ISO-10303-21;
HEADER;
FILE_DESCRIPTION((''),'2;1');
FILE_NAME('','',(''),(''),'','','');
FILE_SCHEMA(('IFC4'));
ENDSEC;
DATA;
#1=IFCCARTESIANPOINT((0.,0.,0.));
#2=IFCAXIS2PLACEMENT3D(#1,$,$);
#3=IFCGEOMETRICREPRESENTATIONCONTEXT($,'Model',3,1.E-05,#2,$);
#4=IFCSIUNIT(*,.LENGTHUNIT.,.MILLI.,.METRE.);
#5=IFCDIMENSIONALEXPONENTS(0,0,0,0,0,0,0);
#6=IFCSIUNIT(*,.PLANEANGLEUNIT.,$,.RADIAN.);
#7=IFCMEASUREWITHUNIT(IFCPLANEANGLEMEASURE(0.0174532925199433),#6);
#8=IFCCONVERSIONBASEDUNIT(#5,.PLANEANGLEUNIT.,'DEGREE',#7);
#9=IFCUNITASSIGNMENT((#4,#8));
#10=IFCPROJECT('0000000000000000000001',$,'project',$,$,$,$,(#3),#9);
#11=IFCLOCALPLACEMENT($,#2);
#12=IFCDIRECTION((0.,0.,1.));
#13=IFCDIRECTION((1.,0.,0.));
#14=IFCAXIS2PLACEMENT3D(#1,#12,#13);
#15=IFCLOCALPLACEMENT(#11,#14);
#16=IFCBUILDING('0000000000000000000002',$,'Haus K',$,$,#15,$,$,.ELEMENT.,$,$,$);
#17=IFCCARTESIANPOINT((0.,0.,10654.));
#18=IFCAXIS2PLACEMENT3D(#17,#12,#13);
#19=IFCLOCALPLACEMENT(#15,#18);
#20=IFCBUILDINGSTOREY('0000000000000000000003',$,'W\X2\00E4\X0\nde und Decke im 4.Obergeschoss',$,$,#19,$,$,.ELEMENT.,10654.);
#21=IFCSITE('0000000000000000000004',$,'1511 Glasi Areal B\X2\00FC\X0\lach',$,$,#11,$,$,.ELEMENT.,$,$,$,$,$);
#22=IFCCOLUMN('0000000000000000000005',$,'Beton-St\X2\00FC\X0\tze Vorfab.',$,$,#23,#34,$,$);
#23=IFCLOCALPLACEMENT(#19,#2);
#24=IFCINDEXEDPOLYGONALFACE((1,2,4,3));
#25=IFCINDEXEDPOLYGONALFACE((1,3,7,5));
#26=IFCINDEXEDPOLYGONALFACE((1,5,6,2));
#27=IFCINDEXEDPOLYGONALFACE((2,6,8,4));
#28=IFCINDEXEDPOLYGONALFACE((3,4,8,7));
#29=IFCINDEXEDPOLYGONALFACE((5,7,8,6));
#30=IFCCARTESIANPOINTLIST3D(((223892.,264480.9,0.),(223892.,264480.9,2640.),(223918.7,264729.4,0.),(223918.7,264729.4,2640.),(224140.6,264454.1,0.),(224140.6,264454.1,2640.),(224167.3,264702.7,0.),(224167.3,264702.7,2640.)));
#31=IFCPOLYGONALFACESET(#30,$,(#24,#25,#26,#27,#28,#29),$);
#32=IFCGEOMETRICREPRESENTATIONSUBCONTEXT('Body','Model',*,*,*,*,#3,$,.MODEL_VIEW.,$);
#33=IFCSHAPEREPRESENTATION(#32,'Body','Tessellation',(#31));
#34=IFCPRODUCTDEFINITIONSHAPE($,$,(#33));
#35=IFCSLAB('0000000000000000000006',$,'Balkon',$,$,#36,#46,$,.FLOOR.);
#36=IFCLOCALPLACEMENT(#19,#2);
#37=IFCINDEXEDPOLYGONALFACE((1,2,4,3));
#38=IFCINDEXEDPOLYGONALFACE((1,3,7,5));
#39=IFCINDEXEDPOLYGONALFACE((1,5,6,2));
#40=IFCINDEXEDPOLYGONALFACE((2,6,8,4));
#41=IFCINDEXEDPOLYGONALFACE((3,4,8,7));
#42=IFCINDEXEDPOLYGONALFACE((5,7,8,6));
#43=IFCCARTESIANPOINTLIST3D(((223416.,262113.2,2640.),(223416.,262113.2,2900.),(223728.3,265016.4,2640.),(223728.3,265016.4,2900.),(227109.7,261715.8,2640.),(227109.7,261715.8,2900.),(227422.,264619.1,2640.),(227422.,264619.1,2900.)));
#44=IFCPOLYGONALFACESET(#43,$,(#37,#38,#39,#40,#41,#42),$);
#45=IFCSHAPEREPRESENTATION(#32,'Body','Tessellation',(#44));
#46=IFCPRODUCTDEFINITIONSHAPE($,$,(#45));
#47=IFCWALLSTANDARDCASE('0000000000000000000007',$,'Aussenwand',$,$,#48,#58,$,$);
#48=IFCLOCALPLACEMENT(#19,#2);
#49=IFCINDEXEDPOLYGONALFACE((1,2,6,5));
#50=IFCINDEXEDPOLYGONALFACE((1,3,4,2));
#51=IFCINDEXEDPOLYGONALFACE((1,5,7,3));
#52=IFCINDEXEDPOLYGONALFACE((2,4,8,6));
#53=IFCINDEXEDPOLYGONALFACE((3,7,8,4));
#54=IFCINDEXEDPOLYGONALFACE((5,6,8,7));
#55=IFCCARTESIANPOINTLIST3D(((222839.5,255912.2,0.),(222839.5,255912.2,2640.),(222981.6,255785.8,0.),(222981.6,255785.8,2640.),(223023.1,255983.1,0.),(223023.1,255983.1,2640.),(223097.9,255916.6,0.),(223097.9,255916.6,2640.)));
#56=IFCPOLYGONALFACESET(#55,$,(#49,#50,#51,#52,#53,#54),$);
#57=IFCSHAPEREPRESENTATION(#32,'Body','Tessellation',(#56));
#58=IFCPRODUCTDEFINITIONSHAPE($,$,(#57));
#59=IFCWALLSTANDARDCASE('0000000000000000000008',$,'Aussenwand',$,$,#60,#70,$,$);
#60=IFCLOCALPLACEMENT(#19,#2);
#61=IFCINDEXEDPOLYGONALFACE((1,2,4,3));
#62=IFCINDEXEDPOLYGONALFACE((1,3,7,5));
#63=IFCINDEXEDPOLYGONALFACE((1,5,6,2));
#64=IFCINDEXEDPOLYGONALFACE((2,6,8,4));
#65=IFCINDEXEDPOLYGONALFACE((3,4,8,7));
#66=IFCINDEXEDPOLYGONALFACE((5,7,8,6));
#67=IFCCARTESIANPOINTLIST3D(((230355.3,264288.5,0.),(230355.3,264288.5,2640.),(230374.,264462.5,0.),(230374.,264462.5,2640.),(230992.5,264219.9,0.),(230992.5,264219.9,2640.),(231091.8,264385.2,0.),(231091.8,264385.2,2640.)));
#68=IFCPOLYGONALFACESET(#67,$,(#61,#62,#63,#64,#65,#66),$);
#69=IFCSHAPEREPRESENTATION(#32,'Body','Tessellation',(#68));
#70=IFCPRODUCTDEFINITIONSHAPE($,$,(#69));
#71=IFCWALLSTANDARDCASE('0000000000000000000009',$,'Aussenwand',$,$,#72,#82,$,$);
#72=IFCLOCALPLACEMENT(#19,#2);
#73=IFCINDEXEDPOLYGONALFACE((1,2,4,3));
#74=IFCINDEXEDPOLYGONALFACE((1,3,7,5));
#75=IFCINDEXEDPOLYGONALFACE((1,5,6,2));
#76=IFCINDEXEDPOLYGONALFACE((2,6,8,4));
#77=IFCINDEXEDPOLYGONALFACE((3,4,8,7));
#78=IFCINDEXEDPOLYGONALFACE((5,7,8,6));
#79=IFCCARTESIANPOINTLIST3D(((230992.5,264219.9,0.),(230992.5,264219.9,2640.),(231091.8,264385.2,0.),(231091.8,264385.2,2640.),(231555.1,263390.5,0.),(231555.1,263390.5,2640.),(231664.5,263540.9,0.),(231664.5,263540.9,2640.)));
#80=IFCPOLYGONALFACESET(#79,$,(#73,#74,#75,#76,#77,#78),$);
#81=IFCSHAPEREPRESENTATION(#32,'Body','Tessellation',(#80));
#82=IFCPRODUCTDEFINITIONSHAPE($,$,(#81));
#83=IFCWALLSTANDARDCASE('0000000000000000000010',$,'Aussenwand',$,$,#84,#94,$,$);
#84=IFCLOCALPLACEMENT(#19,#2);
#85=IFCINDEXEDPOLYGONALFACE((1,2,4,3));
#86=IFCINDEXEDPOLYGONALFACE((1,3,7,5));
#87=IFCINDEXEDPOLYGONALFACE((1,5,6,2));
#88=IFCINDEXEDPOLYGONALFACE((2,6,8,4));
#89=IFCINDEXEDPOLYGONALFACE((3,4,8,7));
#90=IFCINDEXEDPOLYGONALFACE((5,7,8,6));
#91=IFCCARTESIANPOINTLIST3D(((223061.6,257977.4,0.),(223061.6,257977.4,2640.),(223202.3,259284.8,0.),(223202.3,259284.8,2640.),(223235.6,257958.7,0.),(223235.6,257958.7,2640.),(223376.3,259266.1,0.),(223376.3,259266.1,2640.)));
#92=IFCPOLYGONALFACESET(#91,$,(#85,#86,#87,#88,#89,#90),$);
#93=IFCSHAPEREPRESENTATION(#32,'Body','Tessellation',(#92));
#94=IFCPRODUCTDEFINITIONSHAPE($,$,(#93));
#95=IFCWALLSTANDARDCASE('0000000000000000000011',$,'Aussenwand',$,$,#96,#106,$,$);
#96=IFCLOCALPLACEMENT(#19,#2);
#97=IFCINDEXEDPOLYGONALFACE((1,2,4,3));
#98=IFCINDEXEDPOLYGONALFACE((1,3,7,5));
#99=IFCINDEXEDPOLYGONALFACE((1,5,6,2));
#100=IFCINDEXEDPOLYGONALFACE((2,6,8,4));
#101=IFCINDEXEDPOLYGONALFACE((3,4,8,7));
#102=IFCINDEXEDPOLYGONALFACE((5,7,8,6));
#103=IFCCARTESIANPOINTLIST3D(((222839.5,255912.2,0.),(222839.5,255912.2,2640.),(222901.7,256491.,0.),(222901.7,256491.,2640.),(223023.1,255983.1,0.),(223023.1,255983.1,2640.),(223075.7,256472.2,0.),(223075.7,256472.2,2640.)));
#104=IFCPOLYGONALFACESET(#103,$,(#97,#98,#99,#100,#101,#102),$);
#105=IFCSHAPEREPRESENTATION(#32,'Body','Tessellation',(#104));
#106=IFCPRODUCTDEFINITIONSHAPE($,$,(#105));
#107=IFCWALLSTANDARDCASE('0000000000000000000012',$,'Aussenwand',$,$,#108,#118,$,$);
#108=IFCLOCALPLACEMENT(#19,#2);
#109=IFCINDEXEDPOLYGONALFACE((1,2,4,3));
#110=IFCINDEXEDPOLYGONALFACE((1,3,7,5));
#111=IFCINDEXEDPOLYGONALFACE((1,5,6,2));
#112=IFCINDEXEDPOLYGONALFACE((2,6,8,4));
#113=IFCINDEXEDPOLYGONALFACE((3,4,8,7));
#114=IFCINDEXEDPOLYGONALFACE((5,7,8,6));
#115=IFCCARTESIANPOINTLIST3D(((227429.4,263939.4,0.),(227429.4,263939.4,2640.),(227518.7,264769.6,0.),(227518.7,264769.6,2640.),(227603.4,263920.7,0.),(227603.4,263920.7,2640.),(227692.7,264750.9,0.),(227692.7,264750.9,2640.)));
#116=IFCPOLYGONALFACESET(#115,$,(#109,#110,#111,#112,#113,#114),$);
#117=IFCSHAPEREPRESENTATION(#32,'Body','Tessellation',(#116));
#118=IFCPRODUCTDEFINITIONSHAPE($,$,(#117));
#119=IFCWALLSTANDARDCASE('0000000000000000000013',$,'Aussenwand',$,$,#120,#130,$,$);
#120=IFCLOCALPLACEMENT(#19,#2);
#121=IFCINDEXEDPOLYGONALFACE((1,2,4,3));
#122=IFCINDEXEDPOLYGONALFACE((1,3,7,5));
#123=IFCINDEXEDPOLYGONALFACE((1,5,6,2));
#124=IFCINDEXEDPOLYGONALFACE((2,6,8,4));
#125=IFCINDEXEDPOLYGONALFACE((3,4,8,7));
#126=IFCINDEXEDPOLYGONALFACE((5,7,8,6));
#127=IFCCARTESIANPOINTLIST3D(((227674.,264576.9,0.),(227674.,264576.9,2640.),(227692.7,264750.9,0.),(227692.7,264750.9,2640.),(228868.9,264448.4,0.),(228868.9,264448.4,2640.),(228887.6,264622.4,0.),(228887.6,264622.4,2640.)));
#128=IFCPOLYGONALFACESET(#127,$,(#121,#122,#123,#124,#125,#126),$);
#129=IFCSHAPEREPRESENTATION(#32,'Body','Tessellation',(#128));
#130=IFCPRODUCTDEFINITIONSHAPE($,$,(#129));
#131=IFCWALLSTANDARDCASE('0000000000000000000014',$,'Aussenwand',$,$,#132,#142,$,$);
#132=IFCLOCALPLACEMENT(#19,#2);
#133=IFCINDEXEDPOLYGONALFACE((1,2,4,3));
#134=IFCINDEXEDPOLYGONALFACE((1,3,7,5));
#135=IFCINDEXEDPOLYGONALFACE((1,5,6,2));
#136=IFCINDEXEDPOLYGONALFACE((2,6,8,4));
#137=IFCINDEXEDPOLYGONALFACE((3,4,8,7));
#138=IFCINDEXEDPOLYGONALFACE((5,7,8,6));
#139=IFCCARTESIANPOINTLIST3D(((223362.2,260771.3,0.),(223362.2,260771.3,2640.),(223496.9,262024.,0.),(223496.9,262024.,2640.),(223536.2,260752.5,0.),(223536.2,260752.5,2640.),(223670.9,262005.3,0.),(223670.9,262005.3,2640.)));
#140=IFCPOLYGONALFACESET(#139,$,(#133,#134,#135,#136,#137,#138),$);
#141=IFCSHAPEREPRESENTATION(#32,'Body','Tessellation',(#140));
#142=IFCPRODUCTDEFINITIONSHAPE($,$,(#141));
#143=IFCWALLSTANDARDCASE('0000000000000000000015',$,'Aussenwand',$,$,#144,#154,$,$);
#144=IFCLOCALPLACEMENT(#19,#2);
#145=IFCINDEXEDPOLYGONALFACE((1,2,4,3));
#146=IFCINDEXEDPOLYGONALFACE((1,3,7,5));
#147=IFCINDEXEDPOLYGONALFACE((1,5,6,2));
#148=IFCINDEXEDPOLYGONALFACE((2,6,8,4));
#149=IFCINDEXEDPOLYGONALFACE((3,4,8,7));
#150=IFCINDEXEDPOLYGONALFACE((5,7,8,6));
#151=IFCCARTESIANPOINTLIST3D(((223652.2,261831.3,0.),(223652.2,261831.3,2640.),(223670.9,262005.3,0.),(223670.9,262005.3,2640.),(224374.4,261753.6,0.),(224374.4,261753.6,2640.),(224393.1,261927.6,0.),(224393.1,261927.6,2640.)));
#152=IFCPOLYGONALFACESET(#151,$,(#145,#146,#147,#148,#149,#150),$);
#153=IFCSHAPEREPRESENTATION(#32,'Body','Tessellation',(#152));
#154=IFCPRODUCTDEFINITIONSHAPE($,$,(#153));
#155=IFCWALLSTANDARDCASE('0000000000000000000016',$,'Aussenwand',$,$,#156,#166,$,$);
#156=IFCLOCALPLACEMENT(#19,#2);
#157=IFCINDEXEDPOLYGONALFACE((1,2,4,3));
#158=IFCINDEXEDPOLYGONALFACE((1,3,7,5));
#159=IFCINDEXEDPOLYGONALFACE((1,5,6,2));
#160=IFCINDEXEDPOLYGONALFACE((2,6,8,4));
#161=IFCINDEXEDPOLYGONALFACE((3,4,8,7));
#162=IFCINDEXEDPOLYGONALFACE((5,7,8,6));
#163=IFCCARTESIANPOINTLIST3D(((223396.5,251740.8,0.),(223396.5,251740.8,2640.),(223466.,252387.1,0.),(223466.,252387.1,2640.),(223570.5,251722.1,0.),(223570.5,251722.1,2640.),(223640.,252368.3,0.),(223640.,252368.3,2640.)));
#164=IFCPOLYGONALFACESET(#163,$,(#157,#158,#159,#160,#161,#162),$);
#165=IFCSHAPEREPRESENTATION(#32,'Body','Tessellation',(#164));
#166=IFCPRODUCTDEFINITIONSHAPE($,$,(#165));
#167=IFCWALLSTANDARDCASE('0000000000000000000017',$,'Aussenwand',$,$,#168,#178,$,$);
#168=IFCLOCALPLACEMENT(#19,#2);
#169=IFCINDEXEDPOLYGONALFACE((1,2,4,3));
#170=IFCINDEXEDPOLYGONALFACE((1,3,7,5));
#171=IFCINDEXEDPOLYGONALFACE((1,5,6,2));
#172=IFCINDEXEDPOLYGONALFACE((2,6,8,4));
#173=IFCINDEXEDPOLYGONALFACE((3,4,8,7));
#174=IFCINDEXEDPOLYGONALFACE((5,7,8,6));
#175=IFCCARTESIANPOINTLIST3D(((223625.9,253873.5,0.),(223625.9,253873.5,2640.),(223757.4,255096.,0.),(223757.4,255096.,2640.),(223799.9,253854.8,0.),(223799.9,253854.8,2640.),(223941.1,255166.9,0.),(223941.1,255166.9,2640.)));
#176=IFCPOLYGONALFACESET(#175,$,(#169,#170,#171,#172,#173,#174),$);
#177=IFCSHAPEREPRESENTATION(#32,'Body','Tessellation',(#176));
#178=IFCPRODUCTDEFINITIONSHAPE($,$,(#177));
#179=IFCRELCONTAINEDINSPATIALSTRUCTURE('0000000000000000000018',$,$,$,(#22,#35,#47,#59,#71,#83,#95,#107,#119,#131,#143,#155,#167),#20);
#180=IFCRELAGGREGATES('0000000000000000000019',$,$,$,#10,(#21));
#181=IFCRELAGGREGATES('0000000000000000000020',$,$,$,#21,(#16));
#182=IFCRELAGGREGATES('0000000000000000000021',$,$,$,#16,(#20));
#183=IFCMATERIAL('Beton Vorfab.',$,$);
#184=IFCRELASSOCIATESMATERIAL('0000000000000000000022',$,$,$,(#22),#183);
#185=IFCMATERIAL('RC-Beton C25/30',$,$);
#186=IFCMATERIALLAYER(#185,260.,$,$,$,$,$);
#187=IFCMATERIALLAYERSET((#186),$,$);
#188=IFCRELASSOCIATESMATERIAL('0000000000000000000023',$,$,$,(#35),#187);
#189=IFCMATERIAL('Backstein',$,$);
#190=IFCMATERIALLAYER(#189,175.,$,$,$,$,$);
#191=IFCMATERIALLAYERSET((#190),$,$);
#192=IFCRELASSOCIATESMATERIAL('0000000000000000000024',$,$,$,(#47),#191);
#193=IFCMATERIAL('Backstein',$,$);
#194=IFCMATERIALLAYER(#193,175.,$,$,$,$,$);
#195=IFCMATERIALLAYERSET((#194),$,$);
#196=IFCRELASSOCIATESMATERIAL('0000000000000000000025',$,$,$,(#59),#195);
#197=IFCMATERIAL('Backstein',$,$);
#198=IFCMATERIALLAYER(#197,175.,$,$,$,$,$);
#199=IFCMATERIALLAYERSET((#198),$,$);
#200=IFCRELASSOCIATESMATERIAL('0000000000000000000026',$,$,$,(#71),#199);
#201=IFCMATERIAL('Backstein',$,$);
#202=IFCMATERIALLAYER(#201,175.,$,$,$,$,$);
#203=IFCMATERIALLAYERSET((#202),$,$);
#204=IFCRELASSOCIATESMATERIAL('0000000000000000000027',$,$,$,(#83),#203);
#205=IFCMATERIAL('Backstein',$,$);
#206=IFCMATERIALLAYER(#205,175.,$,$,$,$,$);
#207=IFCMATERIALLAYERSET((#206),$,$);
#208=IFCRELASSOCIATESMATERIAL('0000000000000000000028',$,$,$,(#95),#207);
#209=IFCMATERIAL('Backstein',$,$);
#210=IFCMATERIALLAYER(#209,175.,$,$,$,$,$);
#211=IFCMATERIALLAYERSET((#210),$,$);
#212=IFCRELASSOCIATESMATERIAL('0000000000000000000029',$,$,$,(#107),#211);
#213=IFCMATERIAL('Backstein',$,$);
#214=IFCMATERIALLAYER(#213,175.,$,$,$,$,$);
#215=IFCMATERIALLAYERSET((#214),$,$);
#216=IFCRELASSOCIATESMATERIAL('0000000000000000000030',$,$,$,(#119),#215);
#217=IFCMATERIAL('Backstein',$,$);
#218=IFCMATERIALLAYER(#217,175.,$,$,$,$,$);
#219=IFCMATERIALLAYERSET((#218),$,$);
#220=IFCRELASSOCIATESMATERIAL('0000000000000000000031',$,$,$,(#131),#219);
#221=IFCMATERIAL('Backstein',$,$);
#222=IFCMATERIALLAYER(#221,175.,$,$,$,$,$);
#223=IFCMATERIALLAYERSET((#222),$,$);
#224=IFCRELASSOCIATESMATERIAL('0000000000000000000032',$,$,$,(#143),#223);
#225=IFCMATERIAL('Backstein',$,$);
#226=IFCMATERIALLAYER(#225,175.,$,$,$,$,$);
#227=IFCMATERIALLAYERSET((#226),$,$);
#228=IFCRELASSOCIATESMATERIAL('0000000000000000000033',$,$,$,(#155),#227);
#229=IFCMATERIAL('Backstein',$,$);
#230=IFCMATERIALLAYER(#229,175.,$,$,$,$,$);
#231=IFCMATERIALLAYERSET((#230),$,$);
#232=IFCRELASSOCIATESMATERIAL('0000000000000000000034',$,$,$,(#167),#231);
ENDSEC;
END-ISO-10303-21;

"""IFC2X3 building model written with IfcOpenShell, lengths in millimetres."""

from ifc_helpers import new_model, entity, si_unit, converted_unit, frame, frame_2d, origin, origin_with_axes, place, context, subcontext, project, spatial, polyline, rectangle, outline, extrude, material, layer, layer_set, layer_usage, element, save


model = new_model("IFC2X3")

# Units and contexts
model_context = context("Model", 3, precision=1e-05, world=origin())
body_context = subcontext(model_context, "Body", "Model", "MODEL_VIEW")
ifc_project = project(units=[si_unit("LENGTHUNIT", "METRE", prefix="MILLI"), converted_unit("PLANEANGLEUNIT", "DEGREE", entity("IfcPlaneAngleMeasure", 0.0174532925199433), si_unit("PLANEANGLEUNIT", "RADIAN"), dimensions=[0, 0, 0, 0, 0, 0, 0])], contexts=[model_context])

# Site, building, storey
site_placement = place(None, origin())
site = spatial("IfcSite", under=ifc_project, at=site_placement, Name="1511 Glasi Areal Bülach", CompositionType="ELEMENT")
building_placement = place(site_placement, origin_with_axes())
building = spatial("IfcBuilding", under=site, at=building_placement, Name="Haus K", CompositionType="ELEMENT")
storey_placement = place(building_placement, frame((0.0, 0.0, 10654.0), z_axis=(0.0, 0.0, 1.0), x_axis=(1.0, 0.0, 0.0)))
storey = spatial("IfcBuildingStorey", under=building, at=storey_placement, Name="Wände und Decke im 4.Obergeschoss", CompositionType="ELEMENT", Elevation=10654.0)

# Column
ifc_material_1 = material(Name="Beton Vorfab.")
column_placement = place(storey_placement, frame((223892.0, 264480.9, 0.0), z_axis=(0.0, 0.0, 1.0), x_axis=(1.0, 0.0, 0.0)))
element("IfcColumn", 1, at=column_placement, inside=storey, material=ifc_material_1, Name="Beton-Stütze Vorfab.", context=body_context, shape_type="SweptSolid", body=[
    extrude(rectangle(XDim=250.0, YDim=250.0, at=frame_2d((137.7, 110.9), x_axis=(0.994264, -0.106958))), origin_with_axes(), (0.0, 0.0, 1.0), 2640.0),
])

# Slab
ifc_material_2 = material(Name="RC-Beton C25/30")
ifc_layer_1 = layer(ifc_material_2, 260.0)
ifc_layer_set_1 = layer_set([ifc_layer_1])
ifc_layer_usage_1 = layer_usage(ifc_layer_set_1, "AXIS3", "POSITIVE", 0.0)
slab_placement = place(storey_placement, frame((223728.3, 265016.4, 2640.0), z_axis=(0.0, 0.0, 1.0), x_axis=(1.0, 0.0, 0.0)))
element("IfcSlab", 2, at=slab_placement, inside=storey, material=ifc_layer_usage_1, Name="Balkon", PredefinedType="FLOOR", context=body_context, shape_type="SweptSolid", body=[
    extrude(rectangle(XDim=2920.0, YDim=3715.0, at=frame_2d((1690.7, -1650.3), x_axis=(-0.106958, -0.994264))), origin_with_axes(), (0.0, 0.0, 1.0), 260.0),
])

# Walls
ifc_material_3 = material(Name="Backstein")
ifc_layer_2 = layer(ifc_material_3, 175.0)
ifc_layer_set_2 = layer_set([ifc_layer_2])
ifc_layer_usage_2 = layer_usage(ifc_layer_set_2, "AXIS2", "POSITIVE", 0.0)
wall_1_placement = place(storey_placement, frame((222839.5, 255912.2, 0.0), z_axis=(0.0, 0.0, 1.0), x_axis=(0.747334, -0.664448, 0.0)))
element("IfcWallStandardCase", 3, at=wall_1_placement, inside=storey, material=ifc_layer_usage_2, Name="Aussenwand", context=body_context, shape_type="SweptSolid", body=[
    extrude(outline(polyline([(0.0, 0.0), (190.2, 0.0), (190.2, 175.0), (90.1, 175.0), (0.0, 0.0)])), origin_with_axes(), (0.0, 0.0, 1.0), 2640.0),
])
ifc_material_4 = material(Name="Backstein")
ifc_layer_3 = layer(ifc_material_4, 175.0)
ifc_layer_set_3 = layer_set([ifc_layer_3])
ifc_layer_usage_3 = layer_usage(ifc_layer_set_3, "AXIS2", "POSITIVE", 0.0)
wall_2_placement = place(storey_placement, frame((231091.8, 264385.2, 0.0), z_axis=(0.0, 0.0, 1.0), x_axis=(-0.994264, 0.106958, 0.0)))
element("IfcWallStandardCase", 4, at=wall_2_placement, inside=storey, material=ifc_layer_usage_3, Name="Aussenwand", context=body_context, shape_type="SweptSolid", body=[
    extrude(outline(polyline([(0.0, 0.0), (721.9, 0.0), (721.9, 175.0), (81.1, 175.0), (0.0, 0.0)])), origin_with_axes(), (0.0, 0.0, 1.0), 2640.0),
])
ifc_material_5 = material(Name="Backstein")
ifc_layer_4 = layer(ifc_material_5, 175.0)
ifc_layer_set_4 = layer_set([ifc_layer_4])
ifc_layer_usage_4 = layer_usage(ifc_layer_set_4, "AXIS2", "POSITIVE", 0.0)
wall_3_placement = place(storey_placement, frame((231664.5, 263540.9, 0.0), z_axis=(0.0, 0.0, 1.0), x_axis=(-0.561361, 0.827571, 0.0)))
element("IfcWallStandardCase", 5, at=wall_3_placement, inside=storey, material=ifc_layer_usage_4, Name="Aussenwand", context=body_context, shape_type="SweptSolid", body=[
    extrude(outline(polyline([(0.0, 0.0), (1020.3, 0.0), (939.2, 175.0), (-63.0, 175.0), (0.0, 0.0)])), origin_with_axes(), (0.0, 0.0, 1.0), 2640.0),
])
ifc_material_6 = material(Name="Backstein")
ifc_layer_5 = layer(ifc_material_6, 175.0)
ifc_layer_set_5 = layer_set([ifc_layer_5])
ifc_layer_usage_5 = layer_usage(ifc_layer_set_5, "AXIS2", "POSITIVE", 0.0)
wall_4_placement = place(storey_placement, frame((223202.3, 259284.8, 0.0), z_axis=(0.0, 0.0, 1.0), x_axis=(-0.106958, -0.994264, 0.0)))
element("IfcWallStandardCase", 6, at=wall_4_placement, inside=storey, material=ifc_layer_usage_5, Name="Aussenwand", context=body_context, shape_type="SweptSolid", body=[
    extrude(rectangle(XDim=1315.0, YDim=175.0, at=frame_2d((657.5, 87.5), x_axis=(1.0, 0.0))), origin_with_axes(), (0.0, 0.0, 1.0), 2640.0),
])
ifc_material_7 = material(Name="Backstein")
ifc_layer_6 = layer(ifc_material_7, 175.0)
ifc_layer_set_6 = layer_set([ifc_layer_6])
ifc_layer_usage_6 = layer_usage(ifc_layer_set_6, "AXIS2", "POSITIVE", 0.0)
wall_5_placement = place(storey_placement, frame((222901.7, 256491.0, 0.0), z_axis=(0.0, 0.0, 1.0), x_axis=(-0.106958, -0.994264, 0.0)))
element("IfcWallStandardCase", 7, at=wall_5_placement, inside=storey, material=ifc_layer_usage_6, Name="Aussenwand", context=body_context, shape_type="SweptSolid", body=[
    extrude(outline(polyline([(0.0, 0.0), (582.1, 0.0), (492.0, 175.0), (0.0, 175.0), (0.0, 0.0)])), origin_with_axes(), (0.0, 0.0, 1.0), 2640.0),
])
ifc_material_8 = material(Name="Backstein")
ifc_layer_7 = layer(ifc_material_8, 175.0)
ifc_layer_set_7 = layer_set([ifc_layer_7])
ifc_layer_usage_7 = layer_usage(ifc_layer_set_7, "AXIS2", "POSITIVE", 0.0)
wall_6_placement = place(storey_placement, frame((227518.7, 264769.6, 0.0), z_axis=(0.0, 0.0, 1.0), x_axis=(-0.106958, -0.994264, 0.0)))
element("IfcWallStandardCase", 8, at=wall_6_placement, inside=storey, material=ifc_layer_usage_7, Name="Aussenwand", context=body_context, shape_type="SweptSolid", body=[
    extrude(rectangle(XDim=835.0, YDim=175.0, at=frame_2d((417.5, 87.5), x_axis=(1.0, 0.0))), origin_with_axes(), (0.0, 0.0, 1.0), 2640.0),
])
ifc_material_9 = material(Name="Backstein")
ifc_layer_8 = layer(ifc_material_9, 175.0)
ifc_layer_set_8 = layer_set([ifc_layer_8])
ifc_layer_usage_8 = layer_usage(ifc_layer_set_8, "AXIS2", "POSITIVE", 0.0)
wall_7_placement = place(storey_placement, frame((228887.6, 264622.4, 0.0), z_axis=(0.0, 0.0, 1.0), x_axis=(-0.994264, 0.106958, 0.0)))
element("IfcWallStandardCase", 9, at=wall_7_placement, inside=storey, material=ifc_layer_usage_8, Name="Aussenwand", context=body_context, shape_type="SweptSolid", body=[
    extrude(rectangle(XDim=1201.8, YDim=175.0, at=frame_2d((600.9, 87.5), x_axis=(1.0, 0.0))), origin_with_axes(), (0.0, 0.0, 1.0), 2640.0),
])
ifc_material_10 = material(Name="Backstein")
ifc_layer_9 = layer(ifc_material_10, 175.0)
ifc_layer_set_9 = layer_set([ifc_layer_9])
ifc_layer_usage_9 = layer_usage(ifc_layer_set_9, "AXIS2", "POSITIVE", 0.0)
wall_8_placement = place(storey_placement, frame((223496.9, 262024.0, 0.0), z_axis=(0.0, 0.0, 1.0), x_axis=(-0.106958, -0.994264, 0.0)))
element("IfcWallStandardCase", 10, at=wall_8_placement, inside=storey, material=ifc_layer_usage_9, Name="Aussenwand", context=body_context, shape_type="SweptSolid", body=[
    extrude(rectangle(XDim=1260.0, YDim=175.0, at=frame_2d((630.0, 87.5), x_axis=(1.0, 0.0))), origin_with_axes(), (0.0, 0.0, 1.0), 2640.0),
])
ifc_material_11 = material(Name="Backstein")
ifc_layer_10 = layer(ifc_material_11, 175.0)
ifc_layer_set_10 = layer_set([ifc_layer_10])
ifc_layer_usage_10 = layer_usage(ifc_layer_set_10, "AXIS2", "POSITIVE", 0.0)
wall_9_placement = place(storey_placement, frame((224393.1, 261927.6, 0.0), z_axis=(0.0, 0.0, 1.0), x_axis=(-0.994264, 0.106958, 0.0)))
element("IfcWallStandardCase", 11, at=wall_9_placement, inside=storey, material=ifc_layer_usage_10, Name="Aussenwand", context=body_context, shape_type="SweptSolid", body=[
    extrude(rectangle(XDim=726.3, YDim=175.0, at=frame_2d((363.1, 87.5), x_axis=(1.0, 0.0))), origin_with_axes(), (0.0, 0.0, 1.0), 2640.0),
])
ifc_material_12 = material(Name="Backstein")
ifc_layer_11 = layer(ifc_material_12, 175.0)
ifc_layer_set_11 = layer_set([ifc_layer_11])
ifc_layer_usage_11 = layer_usage(ifc_layer_set_11, "AXIS2", "POSITIVE", 0.0)
wall_10_placement = place(storey_placement, frame((223466.0, 252387.1, 0.0), z_axis=(0.0, 0.0, 1.0), x_axis=(-0.106958, -0.994264, 0.0)))
element("IfcWallStandardCase", 12, at=wall_10_placement, inside=storey, material=ifc_layer_usage_11, Name="Aussenwand", context=body_context, shape_type="SweptSolid", body=[
    extrude(outline(polyline([(0.0, 0.0), (650.0, 0.0), (650.0, 175.0), (0.0, 175.0), (0.0, 0.0)])), origin_with_axes(), (0.0, 0.0, 1.0), 2640.0),
])
ifc_material_13 = material(Name="Backstein")
ifc_layer_12 = layer(ifc_material_13, 175.0)
ifc_layer_set_12 = layer_set([ifc_layer_12])
ifc_layer_usage_12 = layer_usage(ifc_layer_set_12, "AXIS2", "POSITIVE", 0.0)
wall_11_placement = place(storey_placement, frame((223757.4, 255096.0, 0.0), z_axis=(0.0, 0.0, 1.0), x_axis=(-0.106958, -0.994264, 0.0)))
element("IfcWallStandardCase", 13, at=wall_11_placement, inside=storey, material=ifc_layer_usage_12, Name="Aussenwand", context=body_context, shape_type="SweptSolid", body=[
    extrude(outline(polyline([(0.0, 0.0), (1229.6, 0.0), (1229.6, 175.0), (-90.1, 175.0), (0.0, 0.0)])), origin_with_axes(), (0.0, 0.0, 1.0), 2640.0),
])

save(model, "model.ifc")
